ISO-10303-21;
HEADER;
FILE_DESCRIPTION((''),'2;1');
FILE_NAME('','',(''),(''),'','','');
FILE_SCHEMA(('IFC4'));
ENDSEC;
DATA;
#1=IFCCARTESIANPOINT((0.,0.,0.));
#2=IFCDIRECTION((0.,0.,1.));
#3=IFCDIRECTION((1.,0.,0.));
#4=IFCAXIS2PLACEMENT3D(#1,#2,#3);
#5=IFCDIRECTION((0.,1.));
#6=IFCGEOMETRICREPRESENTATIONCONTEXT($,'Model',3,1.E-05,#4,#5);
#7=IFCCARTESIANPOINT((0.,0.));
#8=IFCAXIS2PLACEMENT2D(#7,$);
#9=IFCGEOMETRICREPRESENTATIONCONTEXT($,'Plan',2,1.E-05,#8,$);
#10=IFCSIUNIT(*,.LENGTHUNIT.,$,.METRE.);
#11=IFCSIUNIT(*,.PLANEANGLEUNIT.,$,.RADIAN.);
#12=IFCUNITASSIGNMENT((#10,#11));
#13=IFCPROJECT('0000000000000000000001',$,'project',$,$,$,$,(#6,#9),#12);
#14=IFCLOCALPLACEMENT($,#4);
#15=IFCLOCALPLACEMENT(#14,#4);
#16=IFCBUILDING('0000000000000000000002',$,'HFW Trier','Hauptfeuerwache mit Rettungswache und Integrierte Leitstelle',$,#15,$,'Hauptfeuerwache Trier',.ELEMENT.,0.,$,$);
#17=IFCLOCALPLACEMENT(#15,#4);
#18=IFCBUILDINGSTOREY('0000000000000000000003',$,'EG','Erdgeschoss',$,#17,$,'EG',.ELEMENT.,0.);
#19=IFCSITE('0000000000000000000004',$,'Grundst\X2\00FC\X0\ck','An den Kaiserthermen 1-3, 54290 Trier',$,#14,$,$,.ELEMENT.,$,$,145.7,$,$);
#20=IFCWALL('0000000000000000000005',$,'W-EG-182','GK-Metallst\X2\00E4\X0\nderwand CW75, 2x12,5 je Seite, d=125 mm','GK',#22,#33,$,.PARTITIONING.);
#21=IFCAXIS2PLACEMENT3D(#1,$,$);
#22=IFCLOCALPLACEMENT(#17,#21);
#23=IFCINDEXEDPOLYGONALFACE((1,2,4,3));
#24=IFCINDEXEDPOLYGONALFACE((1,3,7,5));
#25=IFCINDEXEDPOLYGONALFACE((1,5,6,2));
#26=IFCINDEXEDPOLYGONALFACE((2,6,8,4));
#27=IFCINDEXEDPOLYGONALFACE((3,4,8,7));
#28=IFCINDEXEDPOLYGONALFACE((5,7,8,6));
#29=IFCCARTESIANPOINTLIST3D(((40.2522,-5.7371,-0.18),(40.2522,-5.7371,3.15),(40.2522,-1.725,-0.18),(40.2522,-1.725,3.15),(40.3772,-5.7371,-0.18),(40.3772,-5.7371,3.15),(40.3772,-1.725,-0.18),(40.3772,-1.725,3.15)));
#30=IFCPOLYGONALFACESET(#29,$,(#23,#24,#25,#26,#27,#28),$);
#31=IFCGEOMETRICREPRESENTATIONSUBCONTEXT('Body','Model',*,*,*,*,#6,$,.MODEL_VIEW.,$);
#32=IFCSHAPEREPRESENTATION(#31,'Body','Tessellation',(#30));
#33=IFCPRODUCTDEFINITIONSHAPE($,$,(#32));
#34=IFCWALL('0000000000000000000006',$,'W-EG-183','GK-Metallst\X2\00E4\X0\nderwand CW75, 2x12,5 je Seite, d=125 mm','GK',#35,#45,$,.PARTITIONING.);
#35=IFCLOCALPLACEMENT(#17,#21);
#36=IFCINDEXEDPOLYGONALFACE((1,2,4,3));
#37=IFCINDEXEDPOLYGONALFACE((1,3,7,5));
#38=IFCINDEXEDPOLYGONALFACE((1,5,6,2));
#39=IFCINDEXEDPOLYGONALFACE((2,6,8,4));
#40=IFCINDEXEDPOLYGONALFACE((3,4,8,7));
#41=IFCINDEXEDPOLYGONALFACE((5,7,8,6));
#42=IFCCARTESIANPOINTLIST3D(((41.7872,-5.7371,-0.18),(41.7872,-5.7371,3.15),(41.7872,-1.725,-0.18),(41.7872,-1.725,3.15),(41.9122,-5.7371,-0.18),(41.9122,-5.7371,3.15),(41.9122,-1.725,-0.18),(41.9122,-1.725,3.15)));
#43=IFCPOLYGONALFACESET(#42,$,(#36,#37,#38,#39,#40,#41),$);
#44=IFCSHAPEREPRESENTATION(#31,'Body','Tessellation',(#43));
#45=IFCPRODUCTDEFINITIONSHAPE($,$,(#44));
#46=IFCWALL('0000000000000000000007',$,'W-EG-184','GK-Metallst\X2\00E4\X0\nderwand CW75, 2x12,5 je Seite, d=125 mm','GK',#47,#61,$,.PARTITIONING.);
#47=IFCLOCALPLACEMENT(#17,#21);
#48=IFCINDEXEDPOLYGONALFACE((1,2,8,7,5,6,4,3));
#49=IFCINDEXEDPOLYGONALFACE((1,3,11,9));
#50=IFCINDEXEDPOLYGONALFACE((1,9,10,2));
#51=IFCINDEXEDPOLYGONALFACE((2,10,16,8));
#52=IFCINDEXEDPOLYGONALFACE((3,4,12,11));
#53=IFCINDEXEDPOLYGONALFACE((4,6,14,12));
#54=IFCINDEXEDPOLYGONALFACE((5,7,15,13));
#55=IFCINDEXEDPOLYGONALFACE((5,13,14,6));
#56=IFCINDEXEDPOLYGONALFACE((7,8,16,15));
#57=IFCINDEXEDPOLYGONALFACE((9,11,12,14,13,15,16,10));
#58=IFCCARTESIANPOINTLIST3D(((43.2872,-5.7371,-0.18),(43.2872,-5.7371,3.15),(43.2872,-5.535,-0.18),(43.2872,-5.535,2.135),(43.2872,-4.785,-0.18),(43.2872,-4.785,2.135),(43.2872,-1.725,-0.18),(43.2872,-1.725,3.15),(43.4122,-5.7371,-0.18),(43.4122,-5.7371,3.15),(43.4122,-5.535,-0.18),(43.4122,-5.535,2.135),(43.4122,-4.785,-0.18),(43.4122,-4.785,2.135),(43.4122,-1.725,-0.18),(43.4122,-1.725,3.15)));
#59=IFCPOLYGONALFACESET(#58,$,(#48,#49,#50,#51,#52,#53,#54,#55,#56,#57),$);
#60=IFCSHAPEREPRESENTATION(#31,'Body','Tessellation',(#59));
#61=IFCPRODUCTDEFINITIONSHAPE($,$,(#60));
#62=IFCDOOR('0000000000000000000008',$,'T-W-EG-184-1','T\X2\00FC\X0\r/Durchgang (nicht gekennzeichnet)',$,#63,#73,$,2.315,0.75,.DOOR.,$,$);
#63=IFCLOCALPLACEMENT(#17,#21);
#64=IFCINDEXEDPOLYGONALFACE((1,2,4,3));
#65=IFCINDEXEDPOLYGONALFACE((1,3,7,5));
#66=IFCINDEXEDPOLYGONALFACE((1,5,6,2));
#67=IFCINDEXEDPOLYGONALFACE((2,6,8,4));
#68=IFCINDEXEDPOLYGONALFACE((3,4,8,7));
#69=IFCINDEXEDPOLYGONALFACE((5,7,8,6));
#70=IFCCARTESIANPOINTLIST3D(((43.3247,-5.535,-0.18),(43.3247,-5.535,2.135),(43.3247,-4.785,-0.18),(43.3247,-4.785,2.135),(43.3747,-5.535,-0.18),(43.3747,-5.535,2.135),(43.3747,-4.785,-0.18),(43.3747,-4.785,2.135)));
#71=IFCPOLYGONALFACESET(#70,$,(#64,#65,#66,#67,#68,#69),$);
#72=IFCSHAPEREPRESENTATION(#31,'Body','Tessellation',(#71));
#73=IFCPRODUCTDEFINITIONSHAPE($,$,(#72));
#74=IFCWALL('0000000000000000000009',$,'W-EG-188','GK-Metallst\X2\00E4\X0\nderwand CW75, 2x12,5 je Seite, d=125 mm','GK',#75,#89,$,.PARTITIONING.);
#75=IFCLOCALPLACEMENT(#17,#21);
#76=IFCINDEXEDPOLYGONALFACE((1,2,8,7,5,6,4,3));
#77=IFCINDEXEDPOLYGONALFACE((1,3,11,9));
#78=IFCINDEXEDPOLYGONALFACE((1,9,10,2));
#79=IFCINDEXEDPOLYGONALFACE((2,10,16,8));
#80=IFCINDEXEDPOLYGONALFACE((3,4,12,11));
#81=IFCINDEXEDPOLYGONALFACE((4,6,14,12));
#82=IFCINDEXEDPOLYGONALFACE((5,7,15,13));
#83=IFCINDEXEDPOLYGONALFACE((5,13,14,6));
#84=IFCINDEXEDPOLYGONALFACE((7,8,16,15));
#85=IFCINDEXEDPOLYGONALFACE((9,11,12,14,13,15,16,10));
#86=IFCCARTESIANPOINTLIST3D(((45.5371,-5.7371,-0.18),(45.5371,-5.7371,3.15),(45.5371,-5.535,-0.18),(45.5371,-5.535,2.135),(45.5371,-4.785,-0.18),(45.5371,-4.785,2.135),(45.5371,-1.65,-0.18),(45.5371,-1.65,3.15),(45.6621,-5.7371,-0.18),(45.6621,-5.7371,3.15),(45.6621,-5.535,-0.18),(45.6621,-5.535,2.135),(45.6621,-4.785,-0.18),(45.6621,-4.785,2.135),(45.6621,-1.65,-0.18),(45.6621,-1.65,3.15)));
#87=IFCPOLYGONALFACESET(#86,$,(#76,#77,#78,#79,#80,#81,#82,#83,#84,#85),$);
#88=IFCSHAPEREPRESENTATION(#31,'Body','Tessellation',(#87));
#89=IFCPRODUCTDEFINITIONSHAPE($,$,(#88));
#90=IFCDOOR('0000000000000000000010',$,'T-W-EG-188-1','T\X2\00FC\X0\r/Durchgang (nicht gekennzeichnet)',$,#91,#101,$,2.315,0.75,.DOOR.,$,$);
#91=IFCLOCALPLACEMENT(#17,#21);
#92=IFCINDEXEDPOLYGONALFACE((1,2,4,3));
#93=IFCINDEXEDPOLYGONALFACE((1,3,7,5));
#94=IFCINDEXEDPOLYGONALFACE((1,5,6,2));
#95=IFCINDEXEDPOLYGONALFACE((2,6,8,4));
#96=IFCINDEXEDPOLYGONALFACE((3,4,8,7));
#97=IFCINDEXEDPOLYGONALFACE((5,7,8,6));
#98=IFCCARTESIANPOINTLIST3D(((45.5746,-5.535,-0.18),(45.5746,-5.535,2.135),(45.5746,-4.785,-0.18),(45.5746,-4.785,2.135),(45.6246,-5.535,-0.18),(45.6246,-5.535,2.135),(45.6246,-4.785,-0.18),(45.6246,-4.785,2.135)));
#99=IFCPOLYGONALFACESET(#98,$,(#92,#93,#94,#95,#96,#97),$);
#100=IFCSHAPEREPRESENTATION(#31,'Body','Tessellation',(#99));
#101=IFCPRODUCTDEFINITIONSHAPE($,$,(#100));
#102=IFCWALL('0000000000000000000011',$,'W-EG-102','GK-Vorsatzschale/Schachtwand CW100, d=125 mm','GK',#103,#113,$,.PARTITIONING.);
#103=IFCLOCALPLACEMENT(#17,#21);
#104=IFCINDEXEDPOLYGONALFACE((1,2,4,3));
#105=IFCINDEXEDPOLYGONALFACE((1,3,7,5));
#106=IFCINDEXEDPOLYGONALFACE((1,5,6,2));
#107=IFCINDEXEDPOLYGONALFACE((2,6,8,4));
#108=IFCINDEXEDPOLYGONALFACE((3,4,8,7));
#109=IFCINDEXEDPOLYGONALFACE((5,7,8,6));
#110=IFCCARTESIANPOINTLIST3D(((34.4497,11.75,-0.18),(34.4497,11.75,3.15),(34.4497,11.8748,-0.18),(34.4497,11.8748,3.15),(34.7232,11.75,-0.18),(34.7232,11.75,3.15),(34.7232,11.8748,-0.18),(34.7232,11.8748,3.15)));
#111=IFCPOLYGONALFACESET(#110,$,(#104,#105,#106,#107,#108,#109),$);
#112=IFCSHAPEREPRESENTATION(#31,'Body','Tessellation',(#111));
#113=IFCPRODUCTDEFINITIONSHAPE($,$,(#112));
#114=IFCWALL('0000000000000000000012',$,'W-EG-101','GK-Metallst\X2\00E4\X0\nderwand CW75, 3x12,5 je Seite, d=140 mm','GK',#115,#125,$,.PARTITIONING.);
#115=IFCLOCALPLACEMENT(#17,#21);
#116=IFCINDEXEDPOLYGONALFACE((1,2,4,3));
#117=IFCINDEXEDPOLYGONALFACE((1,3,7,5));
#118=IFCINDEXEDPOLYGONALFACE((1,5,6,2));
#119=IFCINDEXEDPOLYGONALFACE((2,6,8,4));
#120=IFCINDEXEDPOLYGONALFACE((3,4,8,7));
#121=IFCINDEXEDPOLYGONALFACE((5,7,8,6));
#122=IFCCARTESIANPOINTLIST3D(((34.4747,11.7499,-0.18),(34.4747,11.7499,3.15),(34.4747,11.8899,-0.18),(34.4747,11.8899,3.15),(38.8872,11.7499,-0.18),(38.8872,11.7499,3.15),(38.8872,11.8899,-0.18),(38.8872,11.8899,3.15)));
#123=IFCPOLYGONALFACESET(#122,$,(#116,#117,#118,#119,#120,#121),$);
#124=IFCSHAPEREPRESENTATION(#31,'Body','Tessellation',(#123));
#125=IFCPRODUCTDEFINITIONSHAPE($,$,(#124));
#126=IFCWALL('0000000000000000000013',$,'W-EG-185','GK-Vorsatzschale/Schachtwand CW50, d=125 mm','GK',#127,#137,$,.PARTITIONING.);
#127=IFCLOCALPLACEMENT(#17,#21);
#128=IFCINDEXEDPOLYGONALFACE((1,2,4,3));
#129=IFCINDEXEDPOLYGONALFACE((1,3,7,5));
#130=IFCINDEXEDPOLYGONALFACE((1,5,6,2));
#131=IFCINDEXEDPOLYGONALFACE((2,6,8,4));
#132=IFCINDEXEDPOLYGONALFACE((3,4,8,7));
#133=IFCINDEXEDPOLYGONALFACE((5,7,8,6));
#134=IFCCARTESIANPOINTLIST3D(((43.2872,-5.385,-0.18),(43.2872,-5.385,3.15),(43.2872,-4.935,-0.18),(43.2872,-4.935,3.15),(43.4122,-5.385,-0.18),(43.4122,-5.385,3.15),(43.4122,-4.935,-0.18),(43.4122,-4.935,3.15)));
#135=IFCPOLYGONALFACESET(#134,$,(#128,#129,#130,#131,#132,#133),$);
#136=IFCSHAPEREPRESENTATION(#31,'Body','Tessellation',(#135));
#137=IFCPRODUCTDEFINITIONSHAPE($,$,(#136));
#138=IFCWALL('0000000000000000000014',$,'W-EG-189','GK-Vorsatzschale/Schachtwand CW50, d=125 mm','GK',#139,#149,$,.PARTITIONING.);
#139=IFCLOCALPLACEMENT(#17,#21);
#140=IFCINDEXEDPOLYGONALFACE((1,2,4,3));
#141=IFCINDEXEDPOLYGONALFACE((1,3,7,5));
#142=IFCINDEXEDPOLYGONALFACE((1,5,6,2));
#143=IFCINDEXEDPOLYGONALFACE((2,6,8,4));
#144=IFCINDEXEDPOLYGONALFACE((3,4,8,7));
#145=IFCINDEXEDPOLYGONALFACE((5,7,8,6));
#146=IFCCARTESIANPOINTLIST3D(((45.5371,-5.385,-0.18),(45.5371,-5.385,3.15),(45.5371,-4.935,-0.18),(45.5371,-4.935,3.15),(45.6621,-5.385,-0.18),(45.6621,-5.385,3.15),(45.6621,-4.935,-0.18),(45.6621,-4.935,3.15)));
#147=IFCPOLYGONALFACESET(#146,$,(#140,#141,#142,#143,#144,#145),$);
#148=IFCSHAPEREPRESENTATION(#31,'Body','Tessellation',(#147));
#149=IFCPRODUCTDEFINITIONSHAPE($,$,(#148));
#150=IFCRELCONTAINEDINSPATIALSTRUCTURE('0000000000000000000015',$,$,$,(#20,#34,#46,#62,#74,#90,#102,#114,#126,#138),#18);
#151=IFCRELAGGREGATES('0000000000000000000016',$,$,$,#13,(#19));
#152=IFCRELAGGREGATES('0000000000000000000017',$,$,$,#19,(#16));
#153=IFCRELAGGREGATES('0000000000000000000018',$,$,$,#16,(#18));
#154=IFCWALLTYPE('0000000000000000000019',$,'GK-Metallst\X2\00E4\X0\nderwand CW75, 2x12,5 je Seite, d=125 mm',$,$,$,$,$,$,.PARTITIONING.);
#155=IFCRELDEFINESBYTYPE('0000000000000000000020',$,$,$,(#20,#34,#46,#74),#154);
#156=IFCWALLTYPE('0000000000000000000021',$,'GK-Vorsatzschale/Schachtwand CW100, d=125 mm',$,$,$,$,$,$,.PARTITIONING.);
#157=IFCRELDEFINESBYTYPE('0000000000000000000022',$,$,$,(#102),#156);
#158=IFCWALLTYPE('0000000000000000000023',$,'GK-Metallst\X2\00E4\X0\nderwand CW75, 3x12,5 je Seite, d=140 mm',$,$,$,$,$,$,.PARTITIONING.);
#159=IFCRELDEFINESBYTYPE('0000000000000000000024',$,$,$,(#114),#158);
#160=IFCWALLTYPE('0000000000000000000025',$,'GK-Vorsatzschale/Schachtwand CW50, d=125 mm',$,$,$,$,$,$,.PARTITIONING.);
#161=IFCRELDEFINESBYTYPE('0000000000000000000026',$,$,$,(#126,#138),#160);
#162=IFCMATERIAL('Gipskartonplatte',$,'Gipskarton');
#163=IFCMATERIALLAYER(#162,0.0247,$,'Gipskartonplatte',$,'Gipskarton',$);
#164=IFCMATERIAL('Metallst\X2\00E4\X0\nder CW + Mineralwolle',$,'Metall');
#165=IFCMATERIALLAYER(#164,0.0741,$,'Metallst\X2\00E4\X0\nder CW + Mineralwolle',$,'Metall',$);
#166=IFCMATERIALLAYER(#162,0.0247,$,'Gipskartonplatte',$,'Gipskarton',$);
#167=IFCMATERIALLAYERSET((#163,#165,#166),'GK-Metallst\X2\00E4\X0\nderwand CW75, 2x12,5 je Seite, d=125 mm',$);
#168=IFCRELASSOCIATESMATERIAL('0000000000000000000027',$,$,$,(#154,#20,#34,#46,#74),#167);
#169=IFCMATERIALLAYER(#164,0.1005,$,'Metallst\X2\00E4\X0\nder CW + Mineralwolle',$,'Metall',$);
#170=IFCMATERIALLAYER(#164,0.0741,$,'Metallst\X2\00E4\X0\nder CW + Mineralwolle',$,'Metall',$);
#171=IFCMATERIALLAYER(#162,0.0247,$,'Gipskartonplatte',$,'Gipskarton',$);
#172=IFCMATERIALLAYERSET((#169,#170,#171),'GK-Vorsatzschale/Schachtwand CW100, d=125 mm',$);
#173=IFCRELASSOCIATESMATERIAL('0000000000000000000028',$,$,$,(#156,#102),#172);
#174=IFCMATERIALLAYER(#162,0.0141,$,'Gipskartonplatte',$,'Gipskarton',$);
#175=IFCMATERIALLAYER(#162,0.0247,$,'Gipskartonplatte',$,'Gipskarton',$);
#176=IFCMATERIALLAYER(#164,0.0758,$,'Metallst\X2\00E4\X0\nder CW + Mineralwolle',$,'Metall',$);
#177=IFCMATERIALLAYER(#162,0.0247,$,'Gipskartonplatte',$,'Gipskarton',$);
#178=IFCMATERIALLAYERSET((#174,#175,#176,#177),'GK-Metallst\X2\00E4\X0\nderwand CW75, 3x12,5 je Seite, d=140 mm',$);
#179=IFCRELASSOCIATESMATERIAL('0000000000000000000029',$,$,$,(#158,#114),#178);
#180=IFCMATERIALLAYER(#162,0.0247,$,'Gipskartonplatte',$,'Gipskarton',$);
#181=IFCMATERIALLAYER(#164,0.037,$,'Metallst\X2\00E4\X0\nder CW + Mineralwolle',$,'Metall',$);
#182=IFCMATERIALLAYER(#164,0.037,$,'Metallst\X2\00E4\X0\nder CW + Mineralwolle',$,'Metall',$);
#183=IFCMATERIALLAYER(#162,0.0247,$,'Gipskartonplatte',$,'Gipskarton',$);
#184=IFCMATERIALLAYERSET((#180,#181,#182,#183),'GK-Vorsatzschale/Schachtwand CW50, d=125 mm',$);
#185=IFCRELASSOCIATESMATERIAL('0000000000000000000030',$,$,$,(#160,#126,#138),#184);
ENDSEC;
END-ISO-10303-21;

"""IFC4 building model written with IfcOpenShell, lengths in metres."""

from ifc_helpers import new_model, si_unit, direction, frame, frame_2d, origin_with_axes, origin_2d, place, context, subcontext, project, spatial, rectangle, extrude, material, layer, layer_set, layer_usage, type_object, element, fill, save


model = new_model("IFC4")

# Units and contexts
model_context = context("Model", 3, precision=1e-05, world=origin_with_axes(), true_north=direction((0.0, 1.0)))
plan_context = context("Plan", 2, precision=1e-05, world=origin_2d())
body_context = subcontext(model_context, "Body", "Model", "MODEL_VIEW")
ifc_project = project(units=[si_unit("LENGTHUNIT", "METRE"), si_unit("PLANEANGLEUNIT", "RADIAN")], contexts=[model_context, plan_context])

# Site, building, storey
site_placement = place(None, origin_with_axes())
site = spatial("IfcSite", under=ifc_project, at=site_placement, Name="Grundstück", Description="An den Kaiserthermen 1-3, 54290 Trier", CompositionType="ELEMENT", RefElevation=145.7)
building_placement = place(site_placement, origin_with_axes())
building = spatial("IfcBuilding", under=site, at=building_placement, Name="HFW Trier", Description="Hauptfeuerwache mit Rettungswache und Integrierte Leitstelle", LongName="Hauptfeuerwache Trier", CompositionType="ELEMENT", ElevationOfRefHeight=0.0)
storey_placement = place(building_placement, origin_with_axes())
storey = spatial("IfcBuildingStorey", under=building, at=storey_placement, Name="EG", Description="Erdgeschoss", LongName="EG", CompositionType="ELEMENT", Elevation=0.0)

# Shared definitions
ifc_material_1 = material(Name="Gipskartonplatte", Category="Gipskarton")
ifc_material_2 = material(Name="Metallständer CW + Mineralwolle", Category="Metall")

# Walls
ifc_layer_1 = layer(ifc_material_1, 0.0247, Name="Gipskartonplatte", Category="Gipskarton")
ifc_layer_2 = layer(ifc_material_2, 0.0741, Name="Metallständer CW + Mineralwolle", Category="Metall")
ifc_layer_3 = layer(ifc_material_1, 0.0247, Name="Gipskartonplatte", Category="Gipskarton")
ifc_layer_set_1 = layer_set([ifc_layer_1, ifc_layer_2, ifc_layer_3], Name="GK-Metallständerwand CW75, 2x12,5 je Seite, d=125 mm")
wall_type_1 = type_object("IfcWallType", Name="GK-Metallständerwand CW75, 2x12,5 je Seite, d=125 mm", PredefinedType="PARTITIONING", material=ifc_layer_set_1)
ifc_layer_usage_1 = layer_usage(ifc_layer_set_1, "AXIS2", "POSITIVE", -0.0625)
wall_1_placement = place(storey_placement, frame((40.3147, -1.725, -0.18), z_axis=(0.0, 0.0, 1.0), x_axis=(0.0, -1.0, 0.0)))
element("IfcWall", 1, at=wall_1_placement, inside=storey, type_object=wall_type_1, material=ifc_layer_usage_1, Name="W-EG-182", Description="GK-Metallständerwand CW75, 2x12,5 je Seite, d=125 mm", ObjectType="GK", PredefinedType="PARTITIONING", context=body_context, shape_type="SweptSolid", body=[
    extrude(rectangle(XDim=4.0121, YDim=0.125, at=frame_2d((2.0061, 0.0))), origin_with_axes(), (0.0, 0.0, 1.0), 3.33),
])
ifc_layer_usage_2 = layer_usage(ifc_layer_set_1, "AXIS2", "POSITIVE", -0.0625)
wall_2_placement = place(storey_placement, frame((41.8497, -1.725, -0.18), z_axis=(0.0, 0.0, 1.0), x_axis=(0.0, -1.0, 0.0)))
element("IfcWall", 2, at=wall_2_placement, inside=storey, type_object=wall_type_1, material=ifc_layer_usage_2, Name="W-EG-183", Description="GK-Metallständerwand CW75, 2x12,5 je Seite, d=125 mm", ObjectType="GK", PredefinedType="PARTITIONING", context=body_context, shape_type="SweptSolid", body=[
    extrude(rectangle(XDim=4.0121, YDim=0.125, at=frame_2d((2.0061, 0.0))), origin_with_axes(), (0.0, 0.0, 1.0), 3.33),
])

# Walls, openings, doors
ifc_layer_usage_3 = layer_usage(ifc_layer_set_1, "AXIS2", "POSITIVE", -0.0625)
wall_3_placement = place(storey_placement, frame((43.3497, -1.725, -0.18), z_axis=(0.0, 0.0, 1.0), x_axis=(0.0, -1.0, 0.0)))
wall_3 = element("IfcWall", 3, at=wall_3_placement, inside=storey, type_object=wall_type_1, material=ifc_layer_usage_3, Name="W-EG-184", Description="GK-Metallständerwand CW75, 2x12,5 je Seite, d=125 mm", ObjectType="GK", PredefinedType="PARTITIONING", context=body_context, shape_type="SweptSolid", body=[
    extrude(rectangle(XDim=4.0121, YDim=0.125, at=frame_2d((2.0061, 0.0))), origin_with_axes(), (0.0, 0.0, 1.0), 3.33),
])
opening_1_placement = place(wall_3_placement, frame((3.06, 0.0, 0.0), z_axis=(0.0, 0.0, 1.0), x_axis=(1.0, 0.0, 0.0)))
opening_1 = element("IfcOpeningElement", 4, at=opening_1_placement, cuts=wall_3, PredefinedType="OPENING", context=body_context, shape_type="SweptSolid", body=[
    extrude(rectangle(XDim=0.75, YDim=0.225, at=frame_2d((0.375, 0.0))), origin_with_axes(), (0.0, 0.0, 1.0), 2.315),
])
door_1_placement = place(wall_3_placement, frame((3.06, 0.0, 0.0), z_axis=(0.0, 0.0, 1.0), x_axis=(1.0, 0.0, 0.0)))
door_1 = element("IfcDoor", 5, at=door_1_placement, inside=storey, Name="T-W-EG-184-1", Description="Tür/Durchgang (nicht gekennzeichnet)", OverallHeight=2.315, OverallWidth=0.75, PredefinedType="DOOR", context=body_context, shape_type="SweptSolid", body=[
    extrude(rectangle(XDim=0.75, YDim=0.05, at=frame_2d((0.375, 0.0))), origin_with_axes(), (0.0, 0.0, 1.0), 2.315),
])
fill(opening_1, door_1)
ifc_layer_usage_4 = layer_usage(ifc_layer_set_1, "AXIS2", "POSITIVE", -0.0625)
wall_4_placement = place(storey_placement, frame((45.5996, -1.65, -0.18), z_axis=(0.0, 0.0, 1.0), x_axis=(0.0, -1.0, 0.0)))
wall_4 = element("IfcWall", 6, at=wall_4_placement, inside=storey, type_object=wall_type_1, material=ifc_layer_usage_4, Name="W-EG-188", Description="GK-Metallständerwand CW75, 2x12,5 je Seite, d=125 mm", ObjectType="GK", PredefinedType="PARTITIONING", context=body_context, shape_type="SweptSolid", body=[
    extrude(rectangle(XDim=4.0871, YDim=0.125, at=frame_2d((2.0435, 0.0))), origin_with_axes(), (0.0, 0.0, 1.0), 3.33),
])
opening_2_placement = place(wall_4_placement, frame((3.135, 0.0, 0.0), z_axis=(0.0, 0.0, 1.0), x_axis=(1.0, 0.0, 0.0)))
opening_2 = element("IfcOpeningElement", 7, at=opening_2_placement, cuts=wall_4, PredefinedType="OPENING", context=body_context, shape_type="SweptSolid", body=[
    extrude(rectangle(XDim=0.75, YDim=0.225, at=frame_2d((0.375, 0.0))), origin_with_axes(), (0.0, 0.0, 1.0), 2.315),
])
door_2_placement = place(wall_4_placement, frame((3.135, 0.0, 0.0), z_axis=(0.0, 0.0, 1.0), x_axis=(1.0, 0.0, 0.0)))
door_2 = element("IfcDoor", 8, at=door_2_placement, inside=storey, Name="T-W-EG-188-1", Description="Tür/Durchgang (nicht gekennzeichnet)", OverallHeight=2.315, OverallWidth=0.75, PredefinedType="DOOR", context=body_context, shape_type="SweptSolid", body=[
    extrude(rectangle(XDim=0.75, YDim=0.05, at=frame_2d((0.375, 0.0))), origin_with_axes(), (0.0, 0.0, 1.0), 2.315),
])
fill(opening_2, door_2)

# Walls
ifc_layer_4 = layer(ifc_material_2, 0.1005, Name="Metallständer CW + Mineralwolle", Category="Metall")
ifc_layer_5 = layer(ifc_material_2, 0.0741, Name="Metallständer CW + Mineralwolle", Category="Metall")
ifc_layer_6 = layer(ifc_material_1, 0.0247, Name="Gipskartonplatte", Category="Gipskarton")
ifc_layer_set_2 = layer_set([ifc_layer_4, ifc_layer_5, ifc_layer_6], Name="GK-Vorsatzschale/Schachtwand CW100, d=125 mm")
ifc_layer_usage_5 = layer_usage(ifc_layer_set_2, "AXIS2", "POSITIVE", -0.0624)
wall_type_2 = type_object("IfcWallType", Name="GK-Vorsatzschale/Schachtwand CW100, d=125 mm", PredefinedType="PARTITIONING", material=ifc_layer_set_2)
wall_5_placement = place(storey_placement, frame((34.4497, 11.8124, -0.18), z_axis=(0.0, 0.0, 1.0), x_axis=(1.0, 0.0, 0.0)))
element("IfcWall", 9, at=wall_5_placement, inside=storey, type_object=wall_type_2, material=ifc_layer_usage_5, Name="W-EG-102", Description="GK-Vorsatzschale/Schachtwand CW100, d=125 mm", ObjectType="GK", PredefinedType="PARTITIONING", context=body_context, shape_type="SweptSolid", body=[
    extrude(rectangle(XDim=0.2735, YDim=0.1249, at=frame_2d((0.1367, 0.0))), origin_with_axes(), (0.0, 0.0, 1.0), 3.33),
])
ifc_layer_7 = layer(ifc_material_1, 0.0141, Name="Gipskartonplatte", Category="Gipskarton")
ifc_layer_8 = layer(ifc_material_1, 0.0247, Name="Gipskartonplatte", Category="Gipskarton")
ifc_layer_9 = layer(ifc_material_2, 0.0758, Name="Metallständer CW + Mineralwolle", Category="Metall")
ifc_layer_10 = layer(ifc_material_1, 0.0247, Name="Gipskartonplatte", Category="Gipskarton")
ifc_layer_set_3 = layer_set([ifc_layer_7, ifc_layer_8, ifc_layer_9, ifc_layer_10], Name="GK-Metallständerwand CW75, 3x12,5 je Seite, d=140 mm")
ifc_layer_usage_6 = layer_usage(ifc_layer_set_3, "AXIS2", "POSITIVE", -0.07)
wall_type_3 = type_object("IfcWallType", Name="GK-Metallständerwand CW75, 3x12,5 je Seite, d=140 mm", PredefinedType="PARTITIONING", material=ifc_layer_set_3)
wall_6_placement = place(storey_placement, frame((34.4747, 11.8199, -0.18), z_axis=(0.0, 0.0, 1.0), x_axis=(1.0, 0.0, 0.0)))
element("IfcWall", 10, at=wall_6_placement, inside=storey, type_object=wall_type_3, material=ifc_layer_usage_6, Name="W-EG-101", Description="GK-Metallständerwand CW75, 3x12,5 je Seite, d=140 mm", ObjectType="GK", PredefinedType="PARTITIONING", context=body_context, shape_type="SweptSolid", body=[
    extrude(rectangle(XDim=4.4125, YDim=0.14, at=frame_2d((2.2063, 0.0))), origin_with_axes(), (0.0, 0.0, 1.0), 3.33),
])
ifc_layer_11 = layer(ifc_material_1, 0.0247, Name="Gipskartonplatte", Category="Gipskarton")
ifc_layer_12 = layer(ifc_material_2, 0.037, Name="Metallständer CW + Mineralwolle", Category="Metall")
ifc_layer_13 = layer(ifc_material_2, 0.037, Name="Metallständer CW + Mineralwolle", Category="Metall")
ifc_layer_14 = layer(ifc_material_1, 0.0247, Name="Gipskartonplatte", Category="Gipskarton")
ifc_layer_set_4 = layer_set([ifc_layer_11, ifc_layer_12, ifc_layer_13, ifc_layer_14], Name="GK-Vorsatzschale/Schachtwand CW50, d=125 mm")
ifc_layer_usage_7 = layer_usage(ifc_layer_set_4, "AXIS2", "POSITIVE", -0.0625)
wall_type_4 = type_object("IfcWallType", Name="GK-Vorsatzschale/Schachtwand CW50, d=125 mm", PredefinedType="PARTITIONING", material=ifc_layer_set_4)
wall_7_placement = place(storey_placement, frame((43.3497, -4.935, -0.18), z_axis=(0.0, 0.0, 1.0), x_axis=(0.0, -1.0, 0.0)))
element("IfcWall", 11, at=wall_7_placement, inside=storey, type_object=wall_type_4, material=ifc_layer_usage_7, Name="W-EG-185", Description="GK-Vorsatzschale/Schachtwand CW50, d=125 mm", ObjectType="GK", PredefinedType="PARTITIONING", context=body_context, shape_type="SweptSolid", body=[
    extrude(rectangle(XDim=0.45, YDim=0.125, at=frame_2d((0.225, 0.0))), origin_with_axes(), (0.0, 0.0, 1.0), 3.33),
])
ifc_layer_usage_8 = layer_usage(ifc_layer_set_4, "AXIS2", "POSITIVE", -0.0625)
wall_8_placement = place(storey_placement, frame((45.5996, -4.935, -0.18), z_axis=(0.0, 0.0, 1.0), x_axis=(0.0, -1.0, 0.0)))
element("IfcWall", 12, at=wall_8_placement, inside=storey, type_object=wall_type_4, material=ifc_layer_usage_8, Name="W-EG-189", Description="GK-Vorsatzschale/Schachtwand CW50, d=125 mm", ObjectType="GK", PredefinedType="PARTITIONING", context=body_context, shape_type="SweptSolid", body=[
    extrude(rectangle(XDim=0.45, YDim=0.125, at=frame_2d((0.225, 0.0))), origin_with_axes(), (0.0, 0.0, 1.0), 3.33),
])

save(model, "model.ifc")
